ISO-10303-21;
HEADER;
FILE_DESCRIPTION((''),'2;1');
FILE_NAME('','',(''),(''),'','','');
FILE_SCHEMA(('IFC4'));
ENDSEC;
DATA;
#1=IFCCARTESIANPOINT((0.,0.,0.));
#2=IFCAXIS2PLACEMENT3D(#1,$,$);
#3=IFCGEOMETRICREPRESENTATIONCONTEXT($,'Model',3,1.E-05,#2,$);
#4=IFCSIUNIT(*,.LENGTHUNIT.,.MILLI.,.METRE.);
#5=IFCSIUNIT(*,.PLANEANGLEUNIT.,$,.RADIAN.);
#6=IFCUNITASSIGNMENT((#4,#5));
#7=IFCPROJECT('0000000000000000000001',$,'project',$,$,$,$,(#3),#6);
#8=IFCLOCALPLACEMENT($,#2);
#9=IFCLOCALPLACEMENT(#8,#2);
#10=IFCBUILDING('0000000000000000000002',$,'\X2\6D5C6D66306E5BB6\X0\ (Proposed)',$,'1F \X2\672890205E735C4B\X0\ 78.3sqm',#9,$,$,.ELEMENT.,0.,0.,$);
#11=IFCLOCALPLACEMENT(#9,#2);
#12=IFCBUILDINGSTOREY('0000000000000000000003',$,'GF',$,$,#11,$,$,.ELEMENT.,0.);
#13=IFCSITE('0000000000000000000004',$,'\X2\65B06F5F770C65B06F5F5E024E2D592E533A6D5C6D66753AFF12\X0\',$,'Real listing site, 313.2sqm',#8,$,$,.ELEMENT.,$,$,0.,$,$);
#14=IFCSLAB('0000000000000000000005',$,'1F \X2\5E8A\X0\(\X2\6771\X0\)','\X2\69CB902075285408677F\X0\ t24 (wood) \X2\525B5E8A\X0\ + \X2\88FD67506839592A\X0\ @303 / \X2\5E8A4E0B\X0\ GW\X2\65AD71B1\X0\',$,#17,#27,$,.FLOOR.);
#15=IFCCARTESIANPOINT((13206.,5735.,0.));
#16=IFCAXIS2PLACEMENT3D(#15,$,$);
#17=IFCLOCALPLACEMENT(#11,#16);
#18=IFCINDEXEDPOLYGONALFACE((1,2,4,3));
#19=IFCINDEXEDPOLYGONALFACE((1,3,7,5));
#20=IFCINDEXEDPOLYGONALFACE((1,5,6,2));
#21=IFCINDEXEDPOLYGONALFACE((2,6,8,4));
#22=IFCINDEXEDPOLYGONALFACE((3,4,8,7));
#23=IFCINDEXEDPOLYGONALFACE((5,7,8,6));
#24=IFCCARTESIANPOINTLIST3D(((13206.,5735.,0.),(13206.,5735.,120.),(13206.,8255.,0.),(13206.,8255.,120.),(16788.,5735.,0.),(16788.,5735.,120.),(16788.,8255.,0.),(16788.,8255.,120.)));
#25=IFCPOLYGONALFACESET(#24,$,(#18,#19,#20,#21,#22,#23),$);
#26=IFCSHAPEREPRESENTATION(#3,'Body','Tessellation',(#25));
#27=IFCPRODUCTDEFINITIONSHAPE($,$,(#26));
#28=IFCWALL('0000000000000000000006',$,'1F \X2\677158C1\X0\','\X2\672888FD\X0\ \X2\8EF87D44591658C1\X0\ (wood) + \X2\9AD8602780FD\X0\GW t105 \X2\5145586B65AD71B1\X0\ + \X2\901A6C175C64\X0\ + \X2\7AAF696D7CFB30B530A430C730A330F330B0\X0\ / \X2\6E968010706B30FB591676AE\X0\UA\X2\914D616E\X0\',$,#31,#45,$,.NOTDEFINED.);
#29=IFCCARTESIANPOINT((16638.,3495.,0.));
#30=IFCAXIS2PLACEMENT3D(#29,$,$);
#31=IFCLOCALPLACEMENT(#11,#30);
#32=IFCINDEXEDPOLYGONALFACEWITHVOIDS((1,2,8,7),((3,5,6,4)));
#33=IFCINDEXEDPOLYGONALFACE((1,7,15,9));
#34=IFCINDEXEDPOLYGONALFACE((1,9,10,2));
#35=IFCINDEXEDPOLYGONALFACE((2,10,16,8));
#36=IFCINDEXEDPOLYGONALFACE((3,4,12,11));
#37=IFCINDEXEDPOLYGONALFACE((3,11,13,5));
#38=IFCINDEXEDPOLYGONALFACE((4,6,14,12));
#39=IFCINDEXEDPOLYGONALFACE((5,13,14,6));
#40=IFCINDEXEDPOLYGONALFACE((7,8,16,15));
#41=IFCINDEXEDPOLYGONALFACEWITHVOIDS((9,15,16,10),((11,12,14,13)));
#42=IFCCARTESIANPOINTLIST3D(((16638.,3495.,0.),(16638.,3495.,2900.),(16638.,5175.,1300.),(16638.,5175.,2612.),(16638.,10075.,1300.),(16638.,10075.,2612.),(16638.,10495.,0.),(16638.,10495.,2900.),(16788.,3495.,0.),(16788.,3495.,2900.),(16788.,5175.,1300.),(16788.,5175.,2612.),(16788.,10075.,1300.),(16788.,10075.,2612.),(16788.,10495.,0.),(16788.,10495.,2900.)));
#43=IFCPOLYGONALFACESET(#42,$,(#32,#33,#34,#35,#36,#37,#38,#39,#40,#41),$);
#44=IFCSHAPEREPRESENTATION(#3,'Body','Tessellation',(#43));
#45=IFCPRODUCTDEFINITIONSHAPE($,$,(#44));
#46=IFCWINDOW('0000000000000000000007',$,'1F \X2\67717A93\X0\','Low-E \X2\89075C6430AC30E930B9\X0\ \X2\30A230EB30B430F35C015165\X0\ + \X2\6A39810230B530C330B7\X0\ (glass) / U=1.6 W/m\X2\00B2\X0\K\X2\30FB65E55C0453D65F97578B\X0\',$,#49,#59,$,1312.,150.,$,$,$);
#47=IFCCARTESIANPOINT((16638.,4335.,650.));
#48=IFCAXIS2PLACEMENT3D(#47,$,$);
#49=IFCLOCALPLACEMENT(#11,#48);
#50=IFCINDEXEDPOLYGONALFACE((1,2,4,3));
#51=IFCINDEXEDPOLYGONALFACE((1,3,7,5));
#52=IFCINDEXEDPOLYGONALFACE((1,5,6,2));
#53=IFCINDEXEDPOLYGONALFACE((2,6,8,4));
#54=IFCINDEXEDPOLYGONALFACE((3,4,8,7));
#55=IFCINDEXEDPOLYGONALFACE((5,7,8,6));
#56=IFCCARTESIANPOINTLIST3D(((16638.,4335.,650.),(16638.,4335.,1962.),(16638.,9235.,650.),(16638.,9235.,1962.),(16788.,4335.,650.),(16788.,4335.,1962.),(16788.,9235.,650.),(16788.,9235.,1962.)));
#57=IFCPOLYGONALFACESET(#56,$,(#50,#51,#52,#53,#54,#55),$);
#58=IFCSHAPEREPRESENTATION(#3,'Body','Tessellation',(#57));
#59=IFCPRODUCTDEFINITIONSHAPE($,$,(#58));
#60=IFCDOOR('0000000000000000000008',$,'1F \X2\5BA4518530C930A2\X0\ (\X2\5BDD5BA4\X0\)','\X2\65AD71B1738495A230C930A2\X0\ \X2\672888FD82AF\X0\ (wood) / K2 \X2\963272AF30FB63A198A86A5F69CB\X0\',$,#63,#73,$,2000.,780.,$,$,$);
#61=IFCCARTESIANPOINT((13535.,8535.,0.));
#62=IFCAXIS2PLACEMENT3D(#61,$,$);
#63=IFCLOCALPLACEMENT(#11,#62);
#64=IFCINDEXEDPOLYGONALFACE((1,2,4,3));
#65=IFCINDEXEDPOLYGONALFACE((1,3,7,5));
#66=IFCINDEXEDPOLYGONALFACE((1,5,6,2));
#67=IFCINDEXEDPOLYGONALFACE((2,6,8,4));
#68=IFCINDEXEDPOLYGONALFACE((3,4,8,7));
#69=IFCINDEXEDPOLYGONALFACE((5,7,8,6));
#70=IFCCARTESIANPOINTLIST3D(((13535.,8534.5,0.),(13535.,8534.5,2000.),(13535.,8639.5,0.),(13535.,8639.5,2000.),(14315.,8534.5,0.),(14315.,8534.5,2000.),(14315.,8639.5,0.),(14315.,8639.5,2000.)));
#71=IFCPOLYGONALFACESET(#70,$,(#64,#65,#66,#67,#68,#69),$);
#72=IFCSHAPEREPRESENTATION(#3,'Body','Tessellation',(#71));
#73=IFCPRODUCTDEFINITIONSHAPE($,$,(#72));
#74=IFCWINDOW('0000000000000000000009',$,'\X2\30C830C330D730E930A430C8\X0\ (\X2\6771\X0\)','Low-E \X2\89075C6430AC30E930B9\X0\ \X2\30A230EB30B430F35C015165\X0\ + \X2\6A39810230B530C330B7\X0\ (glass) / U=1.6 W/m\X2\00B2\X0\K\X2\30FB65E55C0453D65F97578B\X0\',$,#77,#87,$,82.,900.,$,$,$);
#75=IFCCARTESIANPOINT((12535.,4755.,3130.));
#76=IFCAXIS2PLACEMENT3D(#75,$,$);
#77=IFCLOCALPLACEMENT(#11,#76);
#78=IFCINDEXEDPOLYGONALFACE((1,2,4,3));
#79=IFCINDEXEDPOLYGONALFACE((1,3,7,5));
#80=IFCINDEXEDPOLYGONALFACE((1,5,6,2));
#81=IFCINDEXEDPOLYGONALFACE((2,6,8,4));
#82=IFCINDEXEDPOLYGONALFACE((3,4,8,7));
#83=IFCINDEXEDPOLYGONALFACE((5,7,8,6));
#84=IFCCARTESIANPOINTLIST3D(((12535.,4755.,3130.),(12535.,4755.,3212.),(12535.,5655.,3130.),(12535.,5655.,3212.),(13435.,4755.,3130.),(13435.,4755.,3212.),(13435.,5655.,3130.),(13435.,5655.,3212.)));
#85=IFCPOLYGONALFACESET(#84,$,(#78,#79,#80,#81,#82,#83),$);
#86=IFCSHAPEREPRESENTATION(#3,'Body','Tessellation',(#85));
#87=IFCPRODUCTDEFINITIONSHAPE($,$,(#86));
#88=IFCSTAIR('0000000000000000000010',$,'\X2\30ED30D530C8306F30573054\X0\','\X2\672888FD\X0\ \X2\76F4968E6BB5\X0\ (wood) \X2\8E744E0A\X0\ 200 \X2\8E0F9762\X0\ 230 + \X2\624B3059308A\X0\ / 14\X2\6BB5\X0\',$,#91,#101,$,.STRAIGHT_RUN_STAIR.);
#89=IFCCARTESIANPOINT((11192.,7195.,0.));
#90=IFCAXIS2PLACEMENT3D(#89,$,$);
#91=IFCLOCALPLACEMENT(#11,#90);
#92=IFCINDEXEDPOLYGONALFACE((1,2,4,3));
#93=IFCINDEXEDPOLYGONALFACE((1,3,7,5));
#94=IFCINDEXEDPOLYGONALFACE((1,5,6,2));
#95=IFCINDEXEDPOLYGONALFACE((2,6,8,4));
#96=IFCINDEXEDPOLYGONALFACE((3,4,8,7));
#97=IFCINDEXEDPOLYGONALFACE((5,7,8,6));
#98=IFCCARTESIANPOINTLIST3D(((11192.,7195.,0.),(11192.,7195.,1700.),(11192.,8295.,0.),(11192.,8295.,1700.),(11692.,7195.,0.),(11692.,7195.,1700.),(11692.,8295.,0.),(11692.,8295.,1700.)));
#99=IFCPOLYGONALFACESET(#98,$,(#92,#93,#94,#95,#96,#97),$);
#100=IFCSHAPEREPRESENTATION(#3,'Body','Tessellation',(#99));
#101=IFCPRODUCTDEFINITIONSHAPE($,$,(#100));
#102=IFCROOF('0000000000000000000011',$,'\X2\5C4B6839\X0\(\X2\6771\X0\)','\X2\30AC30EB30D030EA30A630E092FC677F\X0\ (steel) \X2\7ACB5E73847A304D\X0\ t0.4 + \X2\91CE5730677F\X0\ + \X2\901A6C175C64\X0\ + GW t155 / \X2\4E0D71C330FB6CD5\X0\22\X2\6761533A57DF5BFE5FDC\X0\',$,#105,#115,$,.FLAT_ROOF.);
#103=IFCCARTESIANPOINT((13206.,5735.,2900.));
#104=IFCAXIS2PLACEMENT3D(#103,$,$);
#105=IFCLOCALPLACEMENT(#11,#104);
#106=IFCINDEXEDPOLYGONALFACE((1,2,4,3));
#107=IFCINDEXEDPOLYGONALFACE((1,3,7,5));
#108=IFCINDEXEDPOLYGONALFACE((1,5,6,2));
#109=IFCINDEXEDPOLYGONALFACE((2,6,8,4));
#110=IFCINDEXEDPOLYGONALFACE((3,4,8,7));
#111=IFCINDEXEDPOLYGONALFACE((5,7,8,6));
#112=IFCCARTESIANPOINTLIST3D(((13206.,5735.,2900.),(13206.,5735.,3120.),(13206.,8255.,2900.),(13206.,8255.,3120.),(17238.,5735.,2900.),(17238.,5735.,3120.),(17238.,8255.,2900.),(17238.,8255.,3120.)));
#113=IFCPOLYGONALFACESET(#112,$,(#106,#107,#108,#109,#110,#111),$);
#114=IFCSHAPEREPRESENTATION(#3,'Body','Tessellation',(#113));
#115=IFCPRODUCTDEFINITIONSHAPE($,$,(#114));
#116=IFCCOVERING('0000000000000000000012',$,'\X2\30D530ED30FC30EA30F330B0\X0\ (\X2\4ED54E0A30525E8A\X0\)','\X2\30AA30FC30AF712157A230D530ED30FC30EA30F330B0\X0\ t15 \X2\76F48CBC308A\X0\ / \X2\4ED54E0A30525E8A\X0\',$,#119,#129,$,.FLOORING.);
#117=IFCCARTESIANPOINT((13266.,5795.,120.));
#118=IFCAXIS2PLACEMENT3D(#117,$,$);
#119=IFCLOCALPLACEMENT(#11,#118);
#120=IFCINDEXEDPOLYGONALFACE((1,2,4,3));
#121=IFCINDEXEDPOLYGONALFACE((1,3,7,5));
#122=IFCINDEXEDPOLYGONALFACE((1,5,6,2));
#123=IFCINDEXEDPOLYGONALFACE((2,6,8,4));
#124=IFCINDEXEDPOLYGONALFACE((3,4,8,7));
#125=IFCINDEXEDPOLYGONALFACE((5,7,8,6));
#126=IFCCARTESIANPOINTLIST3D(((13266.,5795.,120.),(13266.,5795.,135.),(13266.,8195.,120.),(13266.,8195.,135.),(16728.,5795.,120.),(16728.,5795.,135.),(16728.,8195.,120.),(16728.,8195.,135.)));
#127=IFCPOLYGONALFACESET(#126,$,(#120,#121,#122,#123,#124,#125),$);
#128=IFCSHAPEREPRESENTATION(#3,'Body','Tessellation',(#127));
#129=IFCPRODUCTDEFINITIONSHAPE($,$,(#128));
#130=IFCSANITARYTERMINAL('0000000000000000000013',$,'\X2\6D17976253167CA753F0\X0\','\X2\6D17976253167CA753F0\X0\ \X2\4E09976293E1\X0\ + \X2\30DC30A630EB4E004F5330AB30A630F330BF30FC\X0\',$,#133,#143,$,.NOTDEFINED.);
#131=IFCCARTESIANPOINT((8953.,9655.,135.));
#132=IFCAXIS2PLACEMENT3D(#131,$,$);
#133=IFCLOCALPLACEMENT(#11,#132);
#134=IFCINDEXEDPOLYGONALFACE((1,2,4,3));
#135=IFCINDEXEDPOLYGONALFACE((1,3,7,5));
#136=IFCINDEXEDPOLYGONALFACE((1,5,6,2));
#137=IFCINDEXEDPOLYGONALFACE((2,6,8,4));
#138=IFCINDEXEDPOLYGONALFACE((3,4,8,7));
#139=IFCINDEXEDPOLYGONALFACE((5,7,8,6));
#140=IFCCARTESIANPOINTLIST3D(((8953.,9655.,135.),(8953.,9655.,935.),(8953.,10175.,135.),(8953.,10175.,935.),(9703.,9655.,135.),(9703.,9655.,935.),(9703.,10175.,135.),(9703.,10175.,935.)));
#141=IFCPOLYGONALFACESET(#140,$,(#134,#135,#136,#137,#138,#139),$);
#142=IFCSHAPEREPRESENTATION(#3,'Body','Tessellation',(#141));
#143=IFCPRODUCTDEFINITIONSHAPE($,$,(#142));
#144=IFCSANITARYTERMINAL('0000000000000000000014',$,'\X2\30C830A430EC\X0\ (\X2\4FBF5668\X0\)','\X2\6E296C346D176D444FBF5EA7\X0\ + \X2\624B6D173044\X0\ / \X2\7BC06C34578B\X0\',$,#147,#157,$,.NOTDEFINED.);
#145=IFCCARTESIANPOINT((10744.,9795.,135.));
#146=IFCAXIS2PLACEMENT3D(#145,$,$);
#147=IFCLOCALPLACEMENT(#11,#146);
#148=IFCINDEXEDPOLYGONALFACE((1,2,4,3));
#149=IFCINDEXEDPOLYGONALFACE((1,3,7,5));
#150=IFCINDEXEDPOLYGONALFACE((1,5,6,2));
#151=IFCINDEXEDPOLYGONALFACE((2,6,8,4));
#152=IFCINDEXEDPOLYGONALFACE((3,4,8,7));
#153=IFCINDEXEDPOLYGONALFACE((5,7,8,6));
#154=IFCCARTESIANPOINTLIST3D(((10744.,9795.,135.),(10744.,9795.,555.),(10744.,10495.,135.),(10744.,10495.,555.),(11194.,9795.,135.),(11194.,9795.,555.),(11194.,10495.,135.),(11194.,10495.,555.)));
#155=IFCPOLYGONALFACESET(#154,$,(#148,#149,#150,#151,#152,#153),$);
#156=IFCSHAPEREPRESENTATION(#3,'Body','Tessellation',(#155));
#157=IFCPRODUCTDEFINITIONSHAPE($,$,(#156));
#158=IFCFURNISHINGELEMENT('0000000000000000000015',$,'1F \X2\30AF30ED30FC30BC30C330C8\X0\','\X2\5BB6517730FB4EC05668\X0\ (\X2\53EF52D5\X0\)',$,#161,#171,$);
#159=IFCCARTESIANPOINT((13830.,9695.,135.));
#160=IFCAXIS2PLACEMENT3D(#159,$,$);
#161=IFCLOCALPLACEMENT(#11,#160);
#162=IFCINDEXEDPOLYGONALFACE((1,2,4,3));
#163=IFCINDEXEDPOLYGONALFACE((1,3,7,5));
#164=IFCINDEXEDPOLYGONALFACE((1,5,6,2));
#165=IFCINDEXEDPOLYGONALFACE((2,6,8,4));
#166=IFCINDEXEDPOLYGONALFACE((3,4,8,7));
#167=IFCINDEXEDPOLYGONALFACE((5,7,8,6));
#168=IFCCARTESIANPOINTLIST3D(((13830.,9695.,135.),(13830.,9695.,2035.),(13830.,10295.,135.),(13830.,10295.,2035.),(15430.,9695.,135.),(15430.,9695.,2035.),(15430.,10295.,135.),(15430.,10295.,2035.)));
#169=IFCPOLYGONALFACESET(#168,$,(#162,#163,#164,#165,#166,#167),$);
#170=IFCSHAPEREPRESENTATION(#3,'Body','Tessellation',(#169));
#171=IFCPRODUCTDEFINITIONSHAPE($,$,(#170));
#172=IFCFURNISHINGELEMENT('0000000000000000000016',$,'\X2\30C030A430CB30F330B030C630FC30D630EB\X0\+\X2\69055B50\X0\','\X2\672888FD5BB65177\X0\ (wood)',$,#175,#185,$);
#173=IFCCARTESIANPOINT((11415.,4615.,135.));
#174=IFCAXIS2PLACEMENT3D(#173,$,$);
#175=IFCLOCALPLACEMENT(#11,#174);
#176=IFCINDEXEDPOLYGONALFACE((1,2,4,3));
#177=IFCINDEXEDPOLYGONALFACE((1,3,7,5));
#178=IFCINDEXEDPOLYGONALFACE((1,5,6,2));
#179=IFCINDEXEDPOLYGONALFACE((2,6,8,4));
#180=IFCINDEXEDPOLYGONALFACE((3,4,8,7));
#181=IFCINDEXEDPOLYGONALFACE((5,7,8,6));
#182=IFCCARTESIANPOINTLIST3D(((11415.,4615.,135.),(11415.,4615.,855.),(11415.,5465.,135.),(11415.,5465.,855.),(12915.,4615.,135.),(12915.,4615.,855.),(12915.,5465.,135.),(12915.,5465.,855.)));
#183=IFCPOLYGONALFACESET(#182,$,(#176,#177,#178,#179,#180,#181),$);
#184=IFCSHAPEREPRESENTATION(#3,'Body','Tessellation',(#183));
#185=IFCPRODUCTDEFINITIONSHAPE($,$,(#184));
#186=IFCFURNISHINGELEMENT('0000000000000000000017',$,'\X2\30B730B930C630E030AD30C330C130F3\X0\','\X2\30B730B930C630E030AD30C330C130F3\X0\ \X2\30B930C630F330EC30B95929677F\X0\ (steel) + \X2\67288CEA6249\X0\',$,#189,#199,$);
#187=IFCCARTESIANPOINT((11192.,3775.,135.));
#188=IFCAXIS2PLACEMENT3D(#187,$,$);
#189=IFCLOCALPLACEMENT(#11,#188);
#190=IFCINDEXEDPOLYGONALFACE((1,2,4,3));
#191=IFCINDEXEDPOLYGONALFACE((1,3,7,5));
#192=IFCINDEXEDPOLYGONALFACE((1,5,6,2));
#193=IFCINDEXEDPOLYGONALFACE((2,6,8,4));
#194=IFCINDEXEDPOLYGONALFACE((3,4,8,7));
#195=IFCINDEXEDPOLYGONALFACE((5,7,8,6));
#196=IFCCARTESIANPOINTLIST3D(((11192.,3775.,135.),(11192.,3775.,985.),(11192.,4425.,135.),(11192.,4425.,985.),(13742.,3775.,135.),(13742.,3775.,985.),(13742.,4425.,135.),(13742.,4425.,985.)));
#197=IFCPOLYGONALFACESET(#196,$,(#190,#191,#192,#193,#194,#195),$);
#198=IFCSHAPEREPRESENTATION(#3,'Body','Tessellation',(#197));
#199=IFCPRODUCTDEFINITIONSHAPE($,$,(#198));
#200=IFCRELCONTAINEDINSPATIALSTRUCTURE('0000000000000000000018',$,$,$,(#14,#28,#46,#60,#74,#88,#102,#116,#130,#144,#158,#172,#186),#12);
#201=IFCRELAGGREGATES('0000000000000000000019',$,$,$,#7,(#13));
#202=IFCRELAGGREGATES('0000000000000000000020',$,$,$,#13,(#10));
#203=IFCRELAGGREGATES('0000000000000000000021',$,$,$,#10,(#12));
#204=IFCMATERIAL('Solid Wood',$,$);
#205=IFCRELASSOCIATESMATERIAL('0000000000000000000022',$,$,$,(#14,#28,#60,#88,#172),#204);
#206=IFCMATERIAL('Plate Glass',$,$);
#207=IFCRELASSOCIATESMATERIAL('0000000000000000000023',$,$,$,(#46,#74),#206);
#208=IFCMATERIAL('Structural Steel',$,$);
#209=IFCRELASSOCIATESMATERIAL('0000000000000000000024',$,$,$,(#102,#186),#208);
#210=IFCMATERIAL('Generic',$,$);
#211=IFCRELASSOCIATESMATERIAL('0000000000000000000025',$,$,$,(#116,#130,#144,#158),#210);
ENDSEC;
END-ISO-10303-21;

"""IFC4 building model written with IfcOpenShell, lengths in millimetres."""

from ifc_helpers import new_model, si_unit, frame, frame_2d, origin, place, context, project, spatial, rectangle, extrude, material, element, fill, save


model = new_model("IFC4")

# Units and contexts
model_context = context("Model", 3, precision=1e-05, world=origin())
ifc_project = project(units=[si_unit("LENGTHUNIT", "METRE", prefix="MILLI"), si_unit("PLANEANGLEUNIT", "RADIAN")], contexts=[model_context])

# Site, building, storey
site_placement = place(None, origin())
site = spatial("IfcSite", under=ifc_project, at=site_placement, Name="新潟県新潟市中央区浜浦町２", ObjectType="Real listing site, 313.2sqm", CompositionType="ELEMENT", RefElevation=0.0)
building_placement = place(site_placement, origin())
building = spatial("IfcBuilding", under=site, at=building_placement, Name="浜浦の家 (Proposed)", ObjectType="1F 木造平屋 78.3sqm", CompositionType="ELEMENT", ElevationOfRefHeight=0.0, ElevationOfTerrain=0.0)
storey_placement = place(building_placement, origin())
storey = spatial("IfcBuildingStorey", under=building, at=storey_placement, Name="GF", CompositionType="ELEMENT", Elevation=0.0)

# Slab
ifc_material_1 = material(Name="Solid Wood")
slab_1_placement = place(storey_placement, frame((13206.0, 5735.0, 0.0)))
element("IfcSlab", 1, at=slab_1_placement, inside=storey, material=ifc_material_1, Name="1F 床(東)", Description="構造用合板 t24 (wood) 剛床 + 製材根太 @303 / 床下 GW断熱", PredefinedType="FLOOR", context=model_context, shape_type="SweptSolid", body=[
    extrude(rectangle(XDim=3582.0, YDim=2520.0, at=frame_2d((1791.0, 1260.0))), frame((13206.0, 5735.0, 0.0)), (0.0, 0.0, 1.0), 120.0),
])

# Wall, opening, window
wall_1_placement = place(storey_placement, frame((16638.0, 3495.0, 0.0)))
wall_1 = element("IfcWall", 2, at=wall_1_placement, inside=storey, material=ifc_material_1, Name="1F 東壁", Description="木製 軸組外壁 (wood) + 高性能GW t105 充填断熱 + 通気層 + 窯業系サイディング / 準耐火・外皮UA配慮", PredefinedType="NOTDEFINED", context=model_context, shape_type="SweptSolid", body=[
    extrude(rectangle(XDim=150.0, YDim=7000.0, at=frame_2d((75.0, 3500.0))), frame((16638.0, 3495.0, 0.0)), (0.0, 0.0, 1.0), 2900.0),
])
opening_1_placement = place(storey_placement, frame((16638.0, 4335.0, 650.0)))
opening_1 = element("IfcOpeningElement", 3, at=opening_1_placement, cuts=wall_1, PredefinedType="NOTDEFINED", context=model_context, shape_type="SweptSolid", body=[
    extrude(rectangle(XDim=150.0, YDim=4900.0, at=frame_2d((75.0, 2450.0))), frame((16638.0, 4335.0, 650.0)), (0.0, 0.0, 1.0), 1312.0),
])
ifc_material_2 = material(Name="Plate Glass")
window_1_placement = place(storey_placement, frame((16638.0, 4335.0, 650.0)))
window_1 = element("IfcWindow", 4, at=window_1_placement, inside=storey, material=ifc_material_2, Name="1F 東窓", Description="Low-E 複層ガラス アルゴン封入 + 樹脂サッシ (glass) / U=1.6 W/m²K・日射取得型", OverallHeight=1312.0, OverallWidth=150.0, context=model_context, shape_type="SweptSolid", body=[
    extrude(rectangle(XDim=150.0, YDim=4900.0, at=frame_2d((75.0, 2450.0))), frame((16638.0, 4335.0, 650.0)), (0.0, 0.0, 1.0), 1312.0),
])
fill(opening_1, window_1)

# Door
door_placement = place(storey_placement, frame((13535.0, 8535.0, 0.0)))
element("IfcDoor", 5, at=door_placement, inside=storey, material=ifc_material_1, Name="1F 室内ドア (寝室)", Description="断熱玄関ドア 木製芯 (wood) / K2 防犯・採風機構", OverallHeight=2000.0, OverallWidth=780.0, context=model_context, shape_type="SweptSolid", body=[
    extrude(rectangle(XDim=780.0, YDim=105.0, at=frame_2d((390.0, 52.0))), frame((13535.0, 8535.0, 0.0)), (0.0, 0.0, 1.0), 2000.0),
])

# Window
window_2_placement = place(storey_placement, frame((12535.0, 4755.0, 3130.0)))
element("IfcWindow", 6, at=window_2_placement, inside=storey, material=ifc_material_2, Name="トップライト (東)", Description="Low-E 複層ガラス アルゴン封入 + 樹脂サッシ (glass) / U=1.6 W/m²K・日射取得型", OverallHeight=82.0, OverallWidth=900.0, context=model_context, shape_type="SweptSolid", body=[
    extrude(rectangle(XDim=900.0, YDim=900.0, at=frame_2d((450.0, 450.0))), frame((12535.0, 4755.0, 3130.0)), (0.0, 0.0, 1.0), 82.0),
])

# Stair
stair_placement = place(storey_placement, frame((11192.0, 7195.0, 0.0)))
element("IfcStair", 7, at=stair_placement, inside=storey, material=ifc_material_1, Name="ロフトはしご", Description="木製 直階段 (wood) 蹴上 200 踏面 230 + 手すり / 14段", PredefinedType="STRAIGHT_RUN_STAIR", context=model_context, shape_type="SweptSolid", body=[
    extrude(rectangle(XDim=500.0, YDim=1100.0, at=frame_2d((250.0, 550.0))), frame((11192.0, 7195.0, 0.0)), (0.0, 0.0, 1.0), 1700.0),
])

# Roof
ifc_material_3 = material(Name="Structural Steel")
roof_placement = place(storey_placement, frame((13206.0, 5735.0, 2900.0)))
element("IfcRoof", 8, at=roof_placement, inside=storey, material=ifc_material_3, Name="屋根(東)", Description="ガルバリウム鋼板 (steel) 立平葺き t0.4 + 野地板 + 通気層 + GW t155 / 不燃・法22条区域対応", PredefinedType="FLAT_ROOF", context=model_context, shape_type="SweptSolid", body=[
    extrude(rectangle(XDim=4032.0, YDim=2520.0, at=frame_2d((2016.0, 1260.0))), frame((13206.0, 5735.0, 2900.0)), (0.0, 0.0, 1.0), 220.0),
])

# Covering
ifc_material_4 = material(Name="Generic")
covering_placement = place(storey_placement, frame((13266.0, 5795.0, 120.0)))
element("IfcCovering", 9, at=covering_placement, inside=storey, material=ifc_material_4, Name="フローリング (仕上げ床)", Description="オーク無垢フローリング t15 直貼り / 仕上げ床", PredefinedType="FLOORING", context=model_context, shape_type="SweptSolid", body=[
    extrude(rectangle(XDim=3462.0, YDim=2400.0, at=frame_2d((1731.0, 1200.0))), frame((13266.0, 5795.0, 120.0)), (0.0, 0.0, 1.0), 15.0),
])

# Sanitary terminals
sanitary_terminal_1_placement = place(storey_placement, frame((8953.0, 9655.0, 135.0)))
element("IfcSanitaryTerminal", 10, at=sanitary_terminal_1_placement, inside=storey, material=ifc_material_4, Name="洗面化粧台", Description="洗面化粧台 三面鏡 + ボウル一体カウンター", PredefinedType="NOTDEFINED", context=model_context, shape_type="SweptSolid", body=[
    extrude(rectangle(XDim=750.0, YDim=520.0, at=frame_2d((375.0, 260.0))), frame((8953.0, 9655.0, 135.0)), (0.0, 0.0, 1.0), 800.0),
])
sanitary_terminal_2_placement = place(storey_placement, frame((10744.0, 9795.0, 135.0)))
element("IfcSanitaryTerminal", 11, at=sanitary_terminal_2_placement, inside=storey, material=ifc_material_4, Name="トイレ (便器)", Description="温水洗浄便座 + 手洗い / 節水型", PredefinedType="NOTDEFINED", context=model_context, shape_type="SweptSolid", body=[
    extrude(rectangle(XDim=450.0, YDim=700.0, at=frame_2d((225.0, 350.0))), frame((10744.0, 9795.0, 135.0)), (0.0, 0.0, 1.0), 420.0),
])

# Furnishing elements
furnishing_1_placement = place(storey_placement, frame((13830.0, 9695.0, 135.0)))
element("IfcFurnishingElement", 12, at=furnishing_1_placement, inside=storey, material=ifc_material_4, Name="1F クローゼット", Description="家具・什器 (可動)", context=model_context, shape_type="SweptSolid", body=[
    extrude(rectangle(XDim=1600.0, YDim=600.0, at=frame_2d((800.0, 300.0))), frame((13830.0, 9695.0, 135.0)), (0.0, 0.0, 1.0), 1900.0),
])
furnishing_2_placement = place(storey_placement, frame((11415.0, 4615.0, 135.0)))
element("IfcFurnishingElement", 13, at=furnishing_2_placement, inside=storey, material=ifc_material_1, Name="ダイニングテーブル+椅子", Description="木製家具 (wood)", context=model_context, shape_type="SweptSolid", body=[
    extrude(rectangle(XDim=1500.0, YDim=850.0, at=frame_2d((750.0, 425.0))), frame((11415.0, 4615.0, 135.0)), (0.0, 0.0, 1.0), 720.0),
])
furnishing_3_placement = place(storey_placement, frame((11192.0, 3775.0, 135.0)))
element("IfcFurnishingElement", 14, at=furnishing_3_placement, inside=storey, material=ifc_material_3, Name="システムキッチン", Description="システムキッチン ステンレス天板 (steel) + 木質扉", context=model_context, shape_type="SweptSolid", body=[
    extrude(rectangle(XDim=2550.0, YDim=650.0, at=frame_2d((1275.0, 325.0))), frame((11192.0, 3775.0, 135.0)), (0.0, 0.0, 1.0), 850.0),
])

save(model, "model.ifc")
